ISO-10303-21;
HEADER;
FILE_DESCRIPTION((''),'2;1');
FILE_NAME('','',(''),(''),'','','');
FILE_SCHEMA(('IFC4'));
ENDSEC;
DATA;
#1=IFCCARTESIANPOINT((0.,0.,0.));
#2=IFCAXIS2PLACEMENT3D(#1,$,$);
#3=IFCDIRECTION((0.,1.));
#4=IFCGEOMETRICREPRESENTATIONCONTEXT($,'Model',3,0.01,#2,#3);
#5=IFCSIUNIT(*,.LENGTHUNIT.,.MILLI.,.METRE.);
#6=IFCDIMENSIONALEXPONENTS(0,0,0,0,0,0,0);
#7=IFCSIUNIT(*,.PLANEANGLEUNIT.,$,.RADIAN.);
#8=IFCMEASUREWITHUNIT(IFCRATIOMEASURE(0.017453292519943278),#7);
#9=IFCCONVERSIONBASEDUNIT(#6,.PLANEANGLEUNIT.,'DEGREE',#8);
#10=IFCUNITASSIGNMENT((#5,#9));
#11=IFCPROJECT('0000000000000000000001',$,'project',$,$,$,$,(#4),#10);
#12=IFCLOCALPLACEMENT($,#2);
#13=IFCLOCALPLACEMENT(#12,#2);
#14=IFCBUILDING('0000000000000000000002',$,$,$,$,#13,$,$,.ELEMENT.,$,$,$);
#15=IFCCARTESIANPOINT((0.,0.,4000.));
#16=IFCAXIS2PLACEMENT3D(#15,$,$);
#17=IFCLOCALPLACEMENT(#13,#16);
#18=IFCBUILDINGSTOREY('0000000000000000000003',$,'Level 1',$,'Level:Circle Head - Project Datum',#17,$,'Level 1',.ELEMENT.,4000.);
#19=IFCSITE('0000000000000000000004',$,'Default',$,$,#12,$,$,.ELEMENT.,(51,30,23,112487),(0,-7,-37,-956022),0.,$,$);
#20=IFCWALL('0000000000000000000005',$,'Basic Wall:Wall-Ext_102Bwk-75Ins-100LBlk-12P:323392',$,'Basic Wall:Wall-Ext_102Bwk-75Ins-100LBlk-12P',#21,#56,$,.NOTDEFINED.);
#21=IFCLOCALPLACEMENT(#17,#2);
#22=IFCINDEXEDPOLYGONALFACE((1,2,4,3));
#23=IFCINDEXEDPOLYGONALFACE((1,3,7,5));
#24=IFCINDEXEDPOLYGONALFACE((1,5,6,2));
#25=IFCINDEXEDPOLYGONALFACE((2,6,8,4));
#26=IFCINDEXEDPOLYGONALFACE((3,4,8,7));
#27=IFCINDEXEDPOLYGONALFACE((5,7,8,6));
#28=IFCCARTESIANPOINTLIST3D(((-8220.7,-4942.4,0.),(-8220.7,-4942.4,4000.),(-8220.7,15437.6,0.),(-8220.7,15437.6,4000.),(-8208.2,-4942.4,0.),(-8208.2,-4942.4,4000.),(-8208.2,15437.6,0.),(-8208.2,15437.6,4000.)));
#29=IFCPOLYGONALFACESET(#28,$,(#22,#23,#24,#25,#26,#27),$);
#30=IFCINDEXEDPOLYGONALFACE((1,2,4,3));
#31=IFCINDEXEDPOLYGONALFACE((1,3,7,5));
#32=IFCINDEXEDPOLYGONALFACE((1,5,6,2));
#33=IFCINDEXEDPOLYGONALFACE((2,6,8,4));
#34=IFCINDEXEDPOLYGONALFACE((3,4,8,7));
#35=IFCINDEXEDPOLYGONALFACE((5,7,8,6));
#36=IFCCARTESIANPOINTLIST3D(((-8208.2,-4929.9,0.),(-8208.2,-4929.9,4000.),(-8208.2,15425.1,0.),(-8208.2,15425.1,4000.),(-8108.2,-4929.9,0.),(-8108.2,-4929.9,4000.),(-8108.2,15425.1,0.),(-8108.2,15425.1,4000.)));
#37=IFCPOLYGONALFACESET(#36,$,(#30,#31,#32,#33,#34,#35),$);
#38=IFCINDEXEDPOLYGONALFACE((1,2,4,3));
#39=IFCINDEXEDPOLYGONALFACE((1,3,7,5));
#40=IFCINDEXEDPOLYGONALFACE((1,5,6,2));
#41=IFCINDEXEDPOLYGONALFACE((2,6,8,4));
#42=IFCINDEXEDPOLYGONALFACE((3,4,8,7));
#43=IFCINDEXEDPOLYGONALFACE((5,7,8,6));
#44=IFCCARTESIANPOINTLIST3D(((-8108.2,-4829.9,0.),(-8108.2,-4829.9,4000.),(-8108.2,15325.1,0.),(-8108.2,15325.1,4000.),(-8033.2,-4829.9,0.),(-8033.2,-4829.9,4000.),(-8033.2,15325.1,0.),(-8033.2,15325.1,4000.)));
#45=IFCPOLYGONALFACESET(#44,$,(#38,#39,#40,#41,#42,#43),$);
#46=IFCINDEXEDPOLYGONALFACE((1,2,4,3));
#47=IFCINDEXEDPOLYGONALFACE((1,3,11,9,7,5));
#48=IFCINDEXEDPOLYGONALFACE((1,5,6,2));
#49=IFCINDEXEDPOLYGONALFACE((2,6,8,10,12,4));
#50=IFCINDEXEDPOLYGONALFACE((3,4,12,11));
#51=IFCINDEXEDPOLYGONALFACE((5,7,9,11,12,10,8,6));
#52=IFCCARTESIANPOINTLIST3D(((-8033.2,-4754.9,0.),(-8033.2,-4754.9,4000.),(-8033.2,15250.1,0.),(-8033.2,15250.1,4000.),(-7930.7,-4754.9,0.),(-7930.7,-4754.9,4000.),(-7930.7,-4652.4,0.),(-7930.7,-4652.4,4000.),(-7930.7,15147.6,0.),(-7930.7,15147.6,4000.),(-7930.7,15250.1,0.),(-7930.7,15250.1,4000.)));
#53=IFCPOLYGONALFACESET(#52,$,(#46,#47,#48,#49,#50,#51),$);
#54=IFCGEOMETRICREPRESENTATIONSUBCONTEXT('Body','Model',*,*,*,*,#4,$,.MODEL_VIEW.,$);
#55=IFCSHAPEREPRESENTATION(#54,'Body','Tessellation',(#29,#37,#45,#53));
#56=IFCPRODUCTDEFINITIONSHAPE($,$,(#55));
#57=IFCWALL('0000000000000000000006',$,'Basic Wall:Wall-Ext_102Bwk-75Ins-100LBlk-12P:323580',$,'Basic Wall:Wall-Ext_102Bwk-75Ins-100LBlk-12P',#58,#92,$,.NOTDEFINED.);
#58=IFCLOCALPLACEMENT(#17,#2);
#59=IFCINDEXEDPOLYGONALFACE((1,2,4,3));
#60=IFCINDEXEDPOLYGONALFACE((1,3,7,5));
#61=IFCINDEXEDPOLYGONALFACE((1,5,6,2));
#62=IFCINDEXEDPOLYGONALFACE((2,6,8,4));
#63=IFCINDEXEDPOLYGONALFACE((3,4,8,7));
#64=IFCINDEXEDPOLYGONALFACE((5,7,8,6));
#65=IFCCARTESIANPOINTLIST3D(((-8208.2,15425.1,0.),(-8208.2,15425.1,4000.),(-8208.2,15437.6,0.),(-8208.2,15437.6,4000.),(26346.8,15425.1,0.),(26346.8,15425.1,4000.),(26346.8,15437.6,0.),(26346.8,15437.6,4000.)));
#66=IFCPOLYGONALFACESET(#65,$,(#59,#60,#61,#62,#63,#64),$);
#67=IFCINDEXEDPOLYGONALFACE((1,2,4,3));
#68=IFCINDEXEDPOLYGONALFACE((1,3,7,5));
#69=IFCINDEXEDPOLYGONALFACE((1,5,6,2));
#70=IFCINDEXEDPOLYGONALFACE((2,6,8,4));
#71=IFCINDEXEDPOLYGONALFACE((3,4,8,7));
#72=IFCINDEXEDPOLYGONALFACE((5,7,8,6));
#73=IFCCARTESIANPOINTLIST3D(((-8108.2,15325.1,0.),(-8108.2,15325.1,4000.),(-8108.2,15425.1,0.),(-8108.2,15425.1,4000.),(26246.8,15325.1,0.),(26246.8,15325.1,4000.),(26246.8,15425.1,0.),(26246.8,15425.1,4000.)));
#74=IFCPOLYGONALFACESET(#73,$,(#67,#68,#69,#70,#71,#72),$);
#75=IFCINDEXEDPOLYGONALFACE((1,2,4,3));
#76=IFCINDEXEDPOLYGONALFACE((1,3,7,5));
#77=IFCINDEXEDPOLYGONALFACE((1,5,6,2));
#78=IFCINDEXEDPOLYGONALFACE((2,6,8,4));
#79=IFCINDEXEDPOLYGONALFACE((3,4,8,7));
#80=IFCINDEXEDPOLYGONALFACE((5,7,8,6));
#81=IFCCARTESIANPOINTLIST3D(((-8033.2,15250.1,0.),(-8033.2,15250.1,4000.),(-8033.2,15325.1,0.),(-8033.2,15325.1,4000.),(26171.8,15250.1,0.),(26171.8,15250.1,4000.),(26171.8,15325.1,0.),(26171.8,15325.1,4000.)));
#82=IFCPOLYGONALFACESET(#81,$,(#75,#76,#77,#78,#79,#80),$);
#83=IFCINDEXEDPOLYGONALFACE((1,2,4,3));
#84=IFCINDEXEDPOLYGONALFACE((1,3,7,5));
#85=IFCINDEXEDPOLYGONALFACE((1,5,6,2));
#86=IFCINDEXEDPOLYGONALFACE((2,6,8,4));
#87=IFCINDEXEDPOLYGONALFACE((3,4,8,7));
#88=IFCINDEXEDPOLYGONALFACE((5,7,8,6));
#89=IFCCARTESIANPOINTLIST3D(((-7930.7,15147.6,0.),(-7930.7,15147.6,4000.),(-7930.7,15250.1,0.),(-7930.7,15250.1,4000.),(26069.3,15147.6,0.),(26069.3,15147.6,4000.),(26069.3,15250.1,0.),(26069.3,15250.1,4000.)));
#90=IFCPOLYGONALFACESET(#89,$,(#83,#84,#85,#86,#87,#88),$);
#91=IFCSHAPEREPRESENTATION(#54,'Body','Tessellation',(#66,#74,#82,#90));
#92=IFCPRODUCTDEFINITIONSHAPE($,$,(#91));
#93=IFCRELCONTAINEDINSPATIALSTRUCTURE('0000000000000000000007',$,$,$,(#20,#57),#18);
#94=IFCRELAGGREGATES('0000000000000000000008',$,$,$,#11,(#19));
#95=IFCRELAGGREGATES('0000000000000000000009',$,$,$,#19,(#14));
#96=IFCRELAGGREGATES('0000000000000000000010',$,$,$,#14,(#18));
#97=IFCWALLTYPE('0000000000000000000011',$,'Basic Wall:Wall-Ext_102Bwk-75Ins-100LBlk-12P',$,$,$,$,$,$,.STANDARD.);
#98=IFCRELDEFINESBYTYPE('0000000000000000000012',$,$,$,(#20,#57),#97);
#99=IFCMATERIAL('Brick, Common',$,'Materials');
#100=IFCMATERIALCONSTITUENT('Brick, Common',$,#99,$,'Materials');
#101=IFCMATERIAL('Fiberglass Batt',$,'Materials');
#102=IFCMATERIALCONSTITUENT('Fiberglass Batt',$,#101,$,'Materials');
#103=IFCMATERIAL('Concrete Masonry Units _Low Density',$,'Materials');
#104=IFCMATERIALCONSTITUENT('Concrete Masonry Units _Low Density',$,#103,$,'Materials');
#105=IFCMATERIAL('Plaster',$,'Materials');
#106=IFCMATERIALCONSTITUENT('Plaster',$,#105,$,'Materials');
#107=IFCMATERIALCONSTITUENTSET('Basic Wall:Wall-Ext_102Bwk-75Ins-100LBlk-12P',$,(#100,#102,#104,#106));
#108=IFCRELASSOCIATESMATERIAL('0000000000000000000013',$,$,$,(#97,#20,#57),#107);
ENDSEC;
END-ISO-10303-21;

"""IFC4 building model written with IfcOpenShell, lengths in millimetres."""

from ifc_helpers import new_model, entity, si_unit, converted_unit, direction, frame, origin, place, context, subcontext, project, spatial, indexed_curve, outline, extrude, material, constituent, constituent_set, type_object, element, save


model = new_model("IFC4")

# Units and contexts
model_context = context("Model", 3, precision=0.01, world=origin(), true_north=direction((0.0, 1.0)))
body_context = subcontext(model_context, "Body", "Model", "MODEL_VIEW")
ifc_project = project(units=[si_unit("LENGTHUNIT", "METRE", prefix="MILLI"), converted_unit("PLANEANGLEUNIT", "DEGREE", entity("IfcRatioMeasure", 0.017453292519943278), si_unit("PLANEANGLEUNIT", "RADIAN"), dimensions=[0, 0, 0, 0, 0, 0, 0])], contexts=[model_context])

# Site, building, storey
site_placement = place(None, origin())
site = spatial("IfcSite", under=ifc_project, at=site_placement, Name="Default", CompositionType="ELEMENT", RefLatitude=(51, 30, 23, 112487), RefLongitude=(0, -7, -37, -956022), RefElevation=0.0)
building_placement = place(site_placement, origin())
building = spatial("IfcBuilding", under=site, at=building_placement, CompositionType="ELEMENT")
storey_placement = place(building_placement, frame((0.0, 0.0, 4000.0)))
storey = spatial("IfcBuildingStorey", under=building, at=storey_placement, Name="Level 1", ObjectType="Level:Circle Head - Project Datum", LongName="Level 1", CompositionType="ELEMENT", Elevation=4000.0)

# Walls
ifc_material_1 = material(Name="Brick, Common", Category="Materials")
ifc_constituent_1 = constituent(ifc_material_1, Name="Brick, Common", Category="Materials")
ifc_material_2 = material(Name="Fiberglass Batt", Category="Materials")
ifc_constituent_2 = constituent(ifc_material_2, Name="Fiberglass Batt", Category="Materials")
ifc_material_3 = material(Name="Concrete Masonry Units _Low Density", Category="Materials")
ifc_constituent_3 = constituent(ifc_material_3, Name="Concrete Masonry Units _Low Density", Category="Materials")
ifc_material_4 = material(Name="Plaster", Category="Materials")
ifc_constituent_4 = constituent(ifc_material_4, Name="Plaster", Category="Materials")
ifc_constituent_set_1 = constituent_set(constituents=[ifc_constituent_1, ifc_constituent_2, ifc_constituent_3, ifc_constituent_4], Name="Basic Wall:Wall-Ext_102Bwk-75Ins-100LBlk-12P")
wall_type = type_object("IfcWallType", Name="Basic Wall:Wall-Ext_102Bwk-75Ins-100LBlk-12P", PredefinedType="STANDARD", material=ifc_constituent_set_1)
wall_1_placement = place(storey_placement, frame((-8075.7, 15437.6, 0.0), z_axis=(0.0, 0.0, 1.0), x_axis=(0.0, -1.0, 0.0)))
element("IfcWall", 1, at=wall_1_placement, inside=storey, type_object=wall_type, material=ifc_constituent_set_1, Name="Basic Wall:Wall-Ext_102Bwk-75Ins-100LBlk-12P:323392", ObjectType="Basic Wall:Wall-Ext_102Bwk-75Ins-100LBlk-12P", PredefinedType="NOTDEFINED", context=body_context, shape_type="SweptSolid", body=[
    extrude(outline(indexed_curve([(-6.3, -10190.0), (6.2, -10190.0), (6.3, 10190.0), (-6.2, 10190.0), (-6.3, -10190.0)], self_intersect=False)), frame((10190.0, -138.7, 0.0), z_axis=(0.0, 0.0, 1.0), x_axis=(0.0, 1.0, 0.0)), (0.0, 0.0, 1.0), 4000.0),
    extrude(outline(indexed_curve([(-10177.5, -50.0), (10177.5, -50.0), (10177.5, 50.0), (-10177.5, 50.0), (-10177.5, -50.0)], self_intersect=False)), frame((10190.0, -82.5, 0.0)), (0.0, 0.0, 1.0), 4000.0),
    extrude(outline(indexed_curve([(-10077.5, -37.5), (10077.5, -37.5), (10077.5, 37.5), (-10077.5, 37.5), (-10077.5, -37.5)], self_intersect=False)), frame((10190.0, 5.0, 0.0)), (0.0, 0.0, 1.0), 4000.0),
    extrude(outline(indexed_curve([(-9900.0, -34.2), (9900.0, -34.2), (10002.5, -34.2), (10002.5, 68.3), (-10002.5, 68.3), (-10002.5, -34.2), (-9900.0, -34.2)], self_intersect=False)), frame((10190.0, 110.8, 0.0), z_axis=(0.0, 0.0, 1.0), x_axis=(-1.0, 0.0, 0.0)), (0.0, 0.0, 1.0), 4000.0),
])
wall_2_placement = place(storey_placement, frame((26069.3, 15292.6, 0.0), z_axis=(0.0, 0.0, 1.0), x_axis=(-1.0, 0.0, 0.0)))
element("IfcWall", 2, at=wall_2_placement, inside=storey, type_object=wall_type, material=ifc_constituent_set_1, Name="Basic Wall:Wall-Ext_102Bwk-75Ins-100LBlk-12P:323580", ObjectType="Basic Wall:Wall-Ext_102Bwk-75Ins-100LBlk-12P", PredefinedType="NOTDEFINED", context=body_context, shape_type="SweptSolid", body=[
    extrude(outline(indexed_curve([(-6.3, -17277.5), (6.2, -17277.5), (6.3, 17277.5), (-6.2, 17277.5), (-6.3, -17277.5)], self_intersect=False)), frame((17000.0, -138.7, 0.0), z_axis=(0.0, 0.0, 1.0), x_axis=(0.0, 1.0, 0.0)), (0.0, 0.0, 1.0), 4000.0),
    extrude(outline(indexed_curve([(-17177.5, -50.0), (17177.5, -50.0), (17177.5, 50.0), (-17177.5, 50.0), (-17177.5, -50.0)], self_intersect=False)), frame((17000.0, -82.5, 0.0)), (0.0, 0.0, 1.0), 4000.0),
    extrude(outline(indexed_curve([(-17102.5, -37.5), (17102.5, -37.5), (17102.5, 37.5), (-17102.5, 37.5), (-17102.5, -37.5)], self_intersect=False)), frame((17000.0, 5.0, 0.0)), (0.0, 0.0, 1.0), 4000.0),
    extrude(outline(indexed_curve([(-51.3, -17000.0), (51.2, -17000.0), (51.3, 17000.0), (-51.2, 17000.0), (-51.3, -17000.0)], self_intersect=False)), frame((17000.0, 93.8, 0.0), z_axis=(0.0, 0.0, 1.0), x_axis=(0.0, -1.0, 0.0)), (0.0, 0.0, 1.0), 4000.0),
])

save(model, "model.ifc")
